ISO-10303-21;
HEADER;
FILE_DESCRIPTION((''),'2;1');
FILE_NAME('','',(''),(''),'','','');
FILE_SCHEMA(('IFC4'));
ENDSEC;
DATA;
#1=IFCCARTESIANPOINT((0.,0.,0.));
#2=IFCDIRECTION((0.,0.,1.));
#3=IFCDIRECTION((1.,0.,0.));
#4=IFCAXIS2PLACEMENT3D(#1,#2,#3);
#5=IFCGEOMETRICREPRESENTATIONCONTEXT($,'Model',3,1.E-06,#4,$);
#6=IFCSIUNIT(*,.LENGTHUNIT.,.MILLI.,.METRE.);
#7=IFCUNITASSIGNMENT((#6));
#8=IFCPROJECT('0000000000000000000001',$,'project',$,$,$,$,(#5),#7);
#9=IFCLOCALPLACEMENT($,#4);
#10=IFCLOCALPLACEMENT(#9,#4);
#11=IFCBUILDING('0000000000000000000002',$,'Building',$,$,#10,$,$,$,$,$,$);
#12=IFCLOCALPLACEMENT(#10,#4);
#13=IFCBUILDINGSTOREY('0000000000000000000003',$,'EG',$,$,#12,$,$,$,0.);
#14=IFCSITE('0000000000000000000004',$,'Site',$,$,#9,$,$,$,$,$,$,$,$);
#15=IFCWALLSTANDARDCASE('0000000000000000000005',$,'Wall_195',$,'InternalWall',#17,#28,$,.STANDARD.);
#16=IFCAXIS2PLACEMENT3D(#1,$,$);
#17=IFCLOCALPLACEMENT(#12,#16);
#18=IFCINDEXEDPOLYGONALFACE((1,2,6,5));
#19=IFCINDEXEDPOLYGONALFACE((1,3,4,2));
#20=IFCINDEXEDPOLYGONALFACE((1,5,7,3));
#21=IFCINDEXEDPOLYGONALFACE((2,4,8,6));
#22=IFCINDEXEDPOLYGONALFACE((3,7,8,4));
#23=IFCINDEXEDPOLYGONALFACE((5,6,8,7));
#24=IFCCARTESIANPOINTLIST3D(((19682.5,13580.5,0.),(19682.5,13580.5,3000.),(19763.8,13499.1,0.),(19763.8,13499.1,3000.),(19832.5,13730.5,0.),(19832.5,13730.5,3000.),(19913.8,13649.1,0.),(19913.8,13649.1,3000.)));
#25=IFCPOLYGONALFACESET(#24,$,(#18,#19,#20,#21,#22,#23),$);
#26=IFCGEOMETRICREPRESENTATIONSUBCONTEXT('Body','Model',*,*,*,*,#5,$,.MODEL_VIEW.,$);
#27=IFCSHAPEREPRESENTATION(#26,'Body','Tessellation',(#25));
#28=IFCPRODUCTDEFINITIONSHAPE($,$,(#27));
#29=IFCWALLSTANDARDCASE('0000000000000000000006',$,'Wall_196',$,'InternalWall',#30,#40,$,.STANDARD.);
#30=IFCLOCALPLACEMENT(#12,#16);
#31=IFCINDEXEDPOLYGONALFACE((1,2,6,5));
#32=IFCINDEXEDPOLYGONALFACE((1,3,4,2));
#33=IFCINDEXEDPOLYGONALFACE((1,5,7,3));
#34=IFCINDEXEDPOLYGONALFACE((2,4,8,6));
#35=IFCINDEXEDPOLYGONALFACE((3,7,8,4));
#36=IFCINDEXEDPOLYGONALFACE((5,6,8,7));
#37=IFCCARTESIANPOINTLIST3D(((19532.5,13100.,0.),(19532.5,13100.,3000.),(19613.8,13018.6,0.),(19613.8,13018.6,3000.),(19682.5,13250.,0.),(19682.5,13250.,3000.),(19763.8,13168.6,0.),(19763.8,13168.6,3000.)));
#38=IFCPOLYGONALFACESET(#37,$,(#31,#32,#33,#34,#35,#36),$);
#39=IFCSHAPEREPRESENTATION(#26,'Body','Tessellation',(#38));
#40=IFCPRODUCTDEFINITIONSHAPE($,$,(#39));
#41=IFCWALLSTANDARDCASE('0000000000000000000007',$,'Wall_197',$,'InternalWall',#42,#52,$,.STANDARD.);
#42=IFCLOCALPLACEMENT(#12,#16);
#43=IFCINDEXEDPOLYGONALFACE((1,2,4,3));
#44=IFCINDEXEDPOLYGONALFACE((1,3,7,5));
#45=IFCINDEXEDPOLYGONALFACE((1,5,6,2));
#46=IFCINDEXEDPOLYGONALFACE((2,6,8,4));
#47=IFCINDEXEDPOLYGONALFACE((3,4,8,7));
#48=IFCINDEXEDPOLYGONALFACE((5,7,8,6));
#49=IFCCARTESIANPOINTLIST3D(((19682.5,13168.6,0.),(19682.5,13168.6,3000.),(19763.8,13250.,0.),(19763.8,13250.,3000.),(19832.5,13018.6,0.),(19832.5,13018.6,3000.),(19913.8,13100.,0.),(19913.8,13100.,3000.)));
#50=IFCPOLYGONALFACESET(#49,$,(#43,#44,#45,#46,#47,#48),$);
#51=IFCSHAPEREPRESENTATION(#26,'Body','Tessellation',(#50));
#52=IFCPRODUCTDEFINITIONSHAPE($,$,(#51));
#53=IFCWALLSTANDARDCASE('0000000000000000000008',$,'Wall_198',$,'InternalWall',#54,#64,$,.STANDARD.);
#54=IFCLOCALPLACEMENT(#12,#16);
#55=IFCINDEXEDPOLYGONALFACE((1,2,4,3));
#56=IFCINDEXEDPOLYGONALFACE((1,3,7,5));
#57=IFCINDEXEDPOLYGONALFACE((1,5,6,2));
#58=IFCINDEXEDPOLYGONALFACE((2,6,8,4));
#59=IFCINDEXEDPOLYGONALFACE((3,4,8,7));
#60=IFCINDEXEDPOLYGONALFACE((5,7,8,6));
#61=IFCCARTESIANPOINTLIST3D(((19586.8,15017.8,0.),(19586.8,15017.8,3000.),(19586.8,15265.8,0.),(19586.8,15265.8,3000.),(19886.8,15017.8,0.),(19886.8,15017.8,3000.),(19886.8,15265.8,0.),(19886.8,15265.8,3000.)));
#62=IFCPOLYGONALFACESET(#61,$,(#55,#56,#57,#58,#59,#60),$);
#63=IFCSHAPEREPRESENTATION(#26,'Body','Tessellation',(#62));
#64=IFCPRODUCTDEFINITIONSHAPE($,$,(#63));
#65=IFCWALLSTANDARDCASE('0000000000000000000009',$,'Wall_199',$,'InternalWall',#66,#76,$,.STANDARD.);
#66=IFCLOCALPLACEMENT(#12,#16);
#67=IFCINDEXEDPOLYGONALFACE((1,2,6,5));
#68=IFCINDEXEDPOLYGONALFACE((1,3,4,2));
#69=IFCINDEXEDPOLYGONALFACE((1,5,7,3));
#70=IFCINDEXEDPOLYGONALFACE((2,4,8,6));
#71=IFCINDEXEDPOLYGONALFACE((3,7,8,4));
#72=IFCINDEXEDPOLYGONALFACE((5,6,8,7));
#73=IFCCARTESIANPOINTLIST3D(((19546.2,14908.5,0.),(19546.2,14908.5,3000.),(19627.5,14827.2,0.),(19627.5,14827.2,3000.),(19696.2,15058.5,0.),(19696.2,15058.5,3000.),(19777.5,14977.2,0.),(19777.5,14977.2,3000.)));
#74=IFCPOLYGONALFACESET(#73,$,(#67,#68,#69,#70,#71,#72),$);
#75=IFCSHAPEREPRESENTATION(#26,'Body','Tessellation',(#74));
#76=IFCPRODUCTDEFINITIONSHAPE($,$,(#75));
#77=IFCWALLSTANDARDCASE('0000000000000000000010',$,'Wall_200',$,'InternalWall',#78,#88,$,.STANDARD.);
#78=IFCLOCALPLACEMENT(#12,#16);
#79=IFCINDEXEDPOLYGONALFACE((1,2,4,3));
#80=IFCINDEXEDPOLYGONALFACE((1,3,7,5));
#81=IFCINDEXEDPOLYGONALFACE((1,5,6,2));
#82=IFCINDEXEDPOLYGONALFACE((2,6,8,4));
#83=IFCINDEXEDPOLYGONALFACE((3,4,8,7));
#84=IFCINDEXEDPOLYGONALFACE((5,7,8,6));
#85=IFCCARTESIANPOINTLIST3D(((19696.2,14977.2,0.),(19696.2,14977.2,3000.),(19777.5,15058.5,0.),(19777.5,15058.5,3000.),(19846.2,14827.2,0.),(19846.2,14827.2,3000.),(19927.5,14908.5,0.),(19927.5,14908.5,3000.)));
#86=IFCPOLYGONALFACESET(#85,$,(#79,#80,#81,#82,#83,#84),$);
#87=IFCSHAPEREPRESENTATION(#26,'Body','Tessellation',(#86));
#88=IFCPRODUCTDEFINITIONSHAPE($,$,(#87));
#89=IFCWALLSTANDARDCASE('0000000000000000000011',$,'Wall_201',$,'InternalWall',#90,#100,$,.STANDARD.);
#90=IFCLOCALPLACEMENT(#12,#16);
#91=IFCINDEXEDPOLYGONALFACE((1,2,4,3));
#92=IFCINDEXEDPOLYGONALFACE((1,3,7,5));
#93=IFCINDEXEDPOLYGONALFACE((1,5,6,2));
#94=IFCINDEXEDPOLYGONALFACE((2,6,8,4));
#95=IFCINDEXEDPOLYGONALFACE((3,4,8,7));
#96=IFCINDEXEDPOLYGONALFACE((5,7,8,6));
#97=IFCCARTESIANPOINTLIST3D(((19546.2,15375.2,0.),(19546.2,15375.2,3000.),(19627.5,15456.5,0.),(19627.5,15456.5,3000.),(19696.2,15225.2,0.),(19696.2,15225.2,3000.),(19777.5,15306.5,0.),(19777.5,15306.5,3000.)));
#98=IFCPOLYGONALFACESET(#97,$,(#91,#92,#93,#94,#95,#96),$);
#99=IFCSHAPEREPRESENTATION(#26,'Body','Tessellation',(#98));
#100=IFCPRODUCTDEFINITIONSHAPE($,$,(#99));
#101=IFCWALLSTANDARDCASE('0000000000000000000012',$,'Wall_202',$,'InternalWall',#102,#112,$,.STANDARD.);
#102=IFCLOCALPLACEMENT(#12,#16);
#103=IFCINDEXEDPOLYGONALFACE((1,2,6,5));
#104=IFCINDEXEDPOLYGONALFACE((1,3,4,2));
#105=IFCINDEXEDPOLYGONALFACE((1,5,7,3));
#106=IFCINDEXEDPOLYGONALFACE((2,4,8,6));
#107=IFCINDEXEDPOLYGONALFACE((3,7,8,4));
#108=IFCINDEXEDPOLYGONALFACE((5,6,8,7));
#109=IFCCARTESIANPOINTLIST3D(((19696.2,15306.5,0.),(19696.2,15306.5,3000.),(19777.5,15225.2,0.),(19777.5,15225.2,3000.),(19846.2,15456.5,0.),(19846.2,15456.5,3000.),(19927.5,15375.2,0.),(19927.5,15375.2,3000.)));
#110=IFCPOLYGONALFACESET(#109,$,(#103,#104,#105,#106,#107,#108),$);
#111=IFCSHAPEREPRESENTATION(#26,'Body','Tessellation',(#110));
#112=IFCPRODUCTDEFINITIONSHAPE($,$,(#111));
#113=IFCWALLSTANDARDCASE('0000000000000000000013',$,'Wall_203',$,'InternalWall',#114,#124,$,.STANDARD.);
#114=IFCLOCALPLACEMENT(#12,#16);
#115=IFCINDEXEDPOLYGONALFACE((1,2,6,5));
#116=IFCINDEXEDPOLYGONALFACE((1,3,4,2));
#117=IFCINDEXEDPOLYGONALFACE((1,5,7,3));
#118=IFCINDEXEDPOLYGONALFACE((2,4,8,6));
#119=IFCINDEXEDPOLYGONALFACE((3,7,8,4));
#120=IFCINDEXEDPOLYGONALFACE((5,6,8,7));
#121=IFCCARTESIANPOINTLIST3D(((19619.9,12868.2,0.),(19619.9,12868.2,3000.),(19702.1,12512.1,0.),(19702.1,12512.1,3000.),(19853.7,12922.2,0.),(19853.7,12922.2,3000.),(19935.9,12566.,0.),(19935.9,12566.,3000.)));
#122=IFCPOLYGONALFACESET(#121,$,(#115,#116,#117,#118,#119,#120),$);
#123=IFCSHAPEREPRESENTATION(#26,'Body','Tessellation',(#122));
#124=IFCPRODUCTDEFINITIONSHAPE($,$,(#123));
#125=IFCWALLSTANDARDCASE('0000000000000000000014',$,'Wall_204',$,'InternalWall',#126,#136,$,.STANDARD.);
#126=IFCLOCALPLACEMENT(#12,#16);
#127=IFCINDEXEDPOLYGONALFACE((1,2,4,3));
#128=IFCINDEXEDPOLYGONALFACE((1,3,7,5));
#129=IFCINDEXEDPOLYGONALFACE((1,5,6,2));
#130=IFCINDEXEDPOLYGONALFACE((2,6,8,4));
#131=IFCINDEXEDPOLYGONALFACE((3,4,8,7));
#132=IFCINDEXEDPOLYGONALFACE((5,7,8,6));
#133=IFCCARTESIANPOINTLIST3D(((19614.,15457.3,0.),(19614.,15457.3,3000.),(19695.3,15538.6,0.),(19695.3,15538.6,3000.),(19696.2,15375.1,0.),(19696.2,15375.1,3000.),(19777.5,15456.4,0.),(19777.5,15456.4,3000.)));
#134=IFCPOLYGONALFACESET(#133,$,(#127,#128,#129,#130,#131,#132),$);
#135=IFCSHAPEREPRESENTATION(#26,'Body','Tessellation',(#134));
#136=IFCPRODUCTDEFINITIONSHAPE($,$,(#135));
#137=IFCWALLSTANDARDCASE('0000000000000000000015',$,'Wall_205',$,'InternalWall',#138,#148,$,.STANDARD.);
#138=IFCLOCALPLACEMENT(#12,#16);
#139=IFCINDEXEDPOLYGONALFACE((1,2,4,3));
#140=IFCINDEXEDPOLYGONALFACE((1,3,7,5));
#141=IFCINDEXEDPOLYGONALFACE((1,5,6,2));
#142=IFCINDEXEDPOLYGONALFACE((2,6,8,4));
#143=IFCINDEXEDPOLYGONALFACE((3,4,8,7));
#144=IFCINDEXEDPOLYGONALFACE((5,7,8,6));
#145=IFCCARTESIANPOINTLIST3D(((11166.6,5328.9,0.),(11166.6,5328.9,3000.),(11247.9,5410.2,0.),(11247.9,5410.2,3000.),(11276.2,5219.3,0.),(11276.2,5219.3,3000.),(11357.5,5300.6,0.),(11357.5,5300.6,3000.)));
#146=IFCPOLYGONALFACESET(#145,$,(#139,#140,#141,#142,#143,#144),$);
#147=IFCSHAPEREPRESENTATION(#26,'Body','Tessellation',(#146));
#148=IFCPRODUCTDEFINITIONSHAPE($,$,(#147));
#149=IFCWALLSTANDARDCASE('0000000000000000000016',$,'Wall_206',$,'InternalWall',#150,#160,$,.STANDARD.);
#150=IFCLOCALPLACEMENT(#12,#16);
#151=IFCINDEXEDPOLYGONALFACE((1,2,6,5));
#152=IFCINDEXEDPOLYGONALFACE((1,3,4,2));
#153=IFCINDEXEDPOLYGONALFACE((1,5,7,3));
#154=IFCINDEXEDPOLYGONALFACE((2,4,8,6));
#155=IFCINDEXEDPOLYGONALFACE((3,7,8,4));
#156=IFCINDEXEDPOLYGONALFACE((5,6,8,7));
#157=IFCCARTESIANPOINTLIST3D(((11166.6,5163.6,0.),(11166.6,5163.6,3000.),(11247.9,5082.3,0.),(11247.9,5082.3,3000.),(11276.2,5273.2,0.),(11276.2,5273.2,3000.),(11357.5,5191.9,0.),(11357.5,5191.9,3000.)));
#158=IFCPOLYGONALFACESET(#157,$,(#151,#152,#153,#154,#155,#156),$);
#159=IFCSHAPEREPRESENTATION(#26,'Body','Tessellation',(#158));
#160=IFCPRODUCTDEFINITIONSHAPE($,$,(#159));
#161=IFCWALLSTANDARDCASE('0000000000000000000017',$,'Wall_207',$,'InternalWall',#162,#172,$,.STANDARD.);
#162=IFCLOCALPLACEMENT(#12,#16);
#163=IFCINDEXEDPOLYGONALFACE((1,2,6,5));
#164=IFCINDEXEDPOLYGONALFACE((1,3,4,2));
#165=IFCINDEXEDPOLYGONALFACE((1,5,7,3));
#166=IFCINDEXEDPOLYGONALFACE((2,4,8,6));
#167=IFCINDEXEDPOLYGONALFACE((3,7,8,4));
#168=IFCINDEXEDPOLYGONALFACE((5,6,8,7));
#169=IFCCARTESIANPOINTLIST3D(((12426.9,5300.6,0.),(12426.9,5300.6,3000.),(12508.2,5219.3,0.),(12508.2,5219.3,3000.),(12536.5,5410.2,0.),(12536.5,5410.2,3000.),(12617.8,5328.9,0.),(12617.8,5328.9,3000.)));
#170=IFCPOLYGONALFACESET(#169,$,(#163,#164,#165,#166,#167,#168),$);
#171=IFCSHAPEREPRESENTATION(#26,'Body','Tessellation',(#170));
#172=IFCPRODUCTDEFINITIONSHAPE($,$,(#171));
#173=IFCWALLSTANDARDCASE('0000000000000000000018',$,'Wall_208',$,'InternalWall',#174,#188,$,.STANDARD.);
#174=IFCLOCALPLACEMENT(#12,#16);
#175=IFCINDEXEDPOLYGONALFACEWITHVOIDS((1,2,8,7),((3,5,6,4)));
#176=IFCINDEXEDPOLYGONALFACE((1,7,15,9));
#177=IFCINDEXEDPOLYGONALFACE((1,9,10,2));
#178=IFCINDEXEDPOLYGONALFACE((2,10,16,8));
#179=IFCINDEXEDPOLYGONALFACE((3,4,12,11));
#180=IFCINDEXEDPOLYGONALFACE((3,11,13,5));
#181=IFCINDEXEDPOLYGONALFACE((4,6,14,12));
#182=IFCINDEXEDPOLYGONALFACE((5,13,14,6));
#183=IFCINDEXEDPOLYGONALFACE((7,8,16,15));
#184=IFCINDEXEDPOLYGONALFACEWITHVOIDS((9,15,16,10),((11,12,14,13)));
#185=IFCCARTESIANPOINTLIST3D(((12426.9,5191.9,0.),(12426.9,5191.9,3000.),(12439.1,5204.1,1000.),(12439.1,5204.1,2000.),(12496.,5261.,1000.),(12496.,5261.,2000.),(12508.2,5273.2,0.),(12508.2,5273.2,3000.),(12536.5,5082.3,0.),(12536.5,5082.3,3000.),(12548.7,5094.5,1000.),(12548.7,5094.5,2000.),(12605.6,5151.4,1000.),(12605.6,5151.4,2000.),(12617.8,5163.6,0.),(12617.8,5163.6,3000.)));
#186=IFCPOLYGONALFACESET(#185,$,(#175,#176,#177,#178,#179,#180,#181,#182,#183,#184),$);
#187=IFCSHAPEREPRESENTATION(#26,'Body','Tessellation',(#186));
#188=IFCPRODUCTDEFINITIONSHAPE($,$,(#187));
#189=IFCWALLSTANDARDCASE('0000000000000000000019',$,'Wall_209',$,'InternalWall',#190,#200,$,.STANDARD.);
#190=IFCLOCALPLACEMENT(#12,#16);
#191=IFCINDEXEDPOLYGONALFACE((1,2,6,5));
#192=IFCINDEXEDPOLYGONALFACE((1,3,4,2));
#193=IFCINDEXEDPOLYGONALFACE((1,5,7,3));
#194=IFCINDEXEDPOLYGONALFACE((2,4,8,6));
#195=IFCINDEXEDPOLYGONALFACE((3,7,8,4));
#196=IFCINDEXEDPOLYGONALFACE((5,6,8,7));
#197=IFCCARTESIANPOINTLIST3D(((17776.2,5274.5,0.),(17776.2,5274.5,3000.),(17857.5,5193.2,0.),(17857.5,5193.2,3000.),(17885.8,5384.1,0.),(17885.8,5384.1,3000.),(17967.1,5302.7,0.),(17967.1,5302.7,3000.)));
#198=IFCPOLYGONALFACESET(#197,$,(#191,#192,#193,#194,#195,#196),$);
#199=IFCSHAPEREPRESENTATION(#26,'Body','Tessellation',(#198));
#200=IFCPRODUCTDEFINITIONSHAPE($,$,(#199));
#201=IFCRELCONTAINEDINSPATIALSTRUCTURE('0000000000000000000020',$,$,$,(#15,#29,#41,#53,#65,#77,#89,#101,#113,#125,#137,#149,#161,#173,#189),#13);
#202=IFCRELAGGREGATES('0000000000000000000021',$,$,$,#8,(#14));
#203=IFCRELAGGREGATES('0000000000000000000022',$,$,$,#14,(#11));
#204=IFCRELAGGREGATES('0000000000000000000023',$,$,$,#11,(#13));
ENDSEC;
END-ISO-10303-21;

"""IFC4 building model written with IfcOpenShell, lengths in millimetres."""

from ifc_helpers import new_model, si_unit, frame, origin_with_axes, place, context, subcontext, project, spatial, rectangle, extrude, element, save


model = new_model("IFC4")

# Units and contexts
model_context = context("Model", 3, precision=1e-06, world=origin_with_axes())
body_context = subcontext(model_context, "Body", "Model", "MODEL_VIEW")
ifc_project = project(units=[si_unit("LENGTHUNIT", "METRE", prefix="MILLI")], contexts=[model_context])

# Site, building, storey
site_placement = place(None, origin_with_axes())
site = spatial("IfcSite", under=ifc_project, at=site_placement, Name="Site")
building_placement = place(site_placement, origin_with_axes())
building = spatial("IfcBuilding", under=site, at=building_placement, Name="Building")
storey_placement = place(building_placement, origin_with_axes())
storey = spatial("IfcBuildingStorey", under=building, at=storey_placement, Name="EG", Elevation=0.0)

# Walls
wall_1_placement = place(storey_placement, origin_with_axes())
element("IfcWallStandardCase", 1, at=wall_1_placement, inside=storey, Name="Wall_195", ObjectType="InternalWall", PredefinedType="STANDARD", context=body_context, shape_type="SweptSolid", body=[
    extrude(rectangle(XDim=212.1, YDim=115.0), frame((19798.1, 13614.8, 0.0), z_axis=(0.0, 0.0, 1.0), x_axis=(0.707107, 0.707107, 0.0)), (0.0, 0.0, 1.0), 3000.0),
])
wall_2_placement = place(storey_placement, origin_with_axes())
element("IfcWallStandardCase", 2, at=wall_2_placement, inside=storey, Name="Wall_196", ObjectType="InternalWall", PredefinedType="STANDARD", context=body_context, shape_type="SweptSolid", body=[
    extrude(rectangle(XDim=212.1, YDim=115.0), frame((19648.1, 13134.3, 0.0), z_axis=(0.0, 0.0, 1.0), x_axis=(-0.707107, -0.707107, 0.0)), (0.0, 0.0, 1.0), 3000.0),
])
wall_3_placement = place(storey_placement, origin_with_axes())
element("IfcWallStandardCase", 3, at=wall_3_placement, inside=storey, Name="Wall_197", ObjectType="InternalWall", PredefinedType="STANDARD", context=body_context, shape_type="SweptSolid", body=[
    extrude(rectangle(XDim=212.1, YDim=115.0), frame((19798.1, 13134.3, 0.0), z_axis=(0.0, 0.0, 1.0), x_axis=(0.707107, -0.707107, 0.0)), (0.0, 0.0, 1.0), 3000.0),
])
wall_4_placement = place(storey_placement, origin_with_axes())
element("IfcWallStandardCase", 4, at=wall_4_placement, inside=storey, Name="Wall_198", ObjectType="InternalWall", PredefinedType="STANDARD", context=body_context, shape_type="SweptSolid", body=[
    extrude(rectangle(XDim=248.0, YDim=300.0), frame((19736.8, 15141.8, 0.0), z_axis=(0.0, 0.0, 1.0), x_axis=(0.0, 1.0, 0.0)), (0.0, 0.0, 1.0), 3000.0),
])
wall_5_placement = place(storey_placement, origin_with_axes())
element("IfcWallStandardCase", 5, at=wall_5_placement, inside=storey, Name="Wall_199", ObjectType="InternalWall", PredefinedType="STANDARD", context=body_context, shape_type="SweptSolid", body=[
    extrude(rectangle(XDim=212.1, YDim=115.0), frame((19661.8, 14942.8, 0.0), z_axis=(0.0, 0.0, 1.0), x_axis=(-0.707107, -0.707107, 0.0)), (0.0, 0.0, 1.0), 3000.0),
])
wall_6_placement = place(storey_placement, origin_with_axes())
element("IfcWallStandardCase", 6, at=wall_6_placement, inside=storey, Name="Wall_200", ObjectType="InternalWall", PredefinedType="STANDARD", context=body_context, shape_type="SweptSolid", body=[
    extrude(rectangle(XDim=212.1, YDim=115.0), frame((19811.8, 14942.8, 0.0), z_axis=(0.0, 0.0, 1.0), x_axis=(0.707107, -0.707107, 0.0)), (0.0, 0.0, 1.0), 3000.0),
])
wall_7_placement = place(storey_placement, origin_with_axes())
element("IfcWallStandardCase", 7, at=wall_7_placement, inside=storey, Name="Wall_201", ObjectType="InternalWall", PredefinedType="STANDARD", context=body_context, shape_type="SweptSolid", body=[
    extrude(rectangle(XDim=212.1, YDim=115.0), frame((19661.8, 15340.8, 0.0), z_axis=(0.0, 0.0, 1.0), x_axis=(-0.707107, 0.707107, 0.0)), (0.0, 0.0, 1.0), 3000.0),
])
wall_8_placement = place(storey_placement, origin_with_axes())
element("IfcWallStandardCase", 8, at=wall_8_placement, inside=storey, Name="Wall_202", ObjectType="InternalWall", PredefinedType="STANDARD", context=body_context, shape_type="SweptSolid", body=[
    extrude(rectangle(XDim=212.1, YDim=115.0), frame((19811.8, 15340.8, 0.0), z_axis=(0.0, 0.0, 1.0), x_axis=(0.707107, 0.707107, 0.0)), (0.0, 0.0, 1.0), 3000.0),
])
wall_9_placement = place(storey_placement, origin_with_axes())
element("IfcWallStandardCase", 9, at=wall_9_placement, inside=storey, Name="Wall_203", ObjectType="InternalWall", PredefinedType="STANDARD", context=body_context, shape_type="SweptSolid", body=[
    extrude(rectangle(XDim=365.5, YDim=240.0), frame((19777.9, 12717.1, 0.0), z_axis=(0.0, 0.0, 1.0), x_axis=(-0.22486, 0.974391, 0.0)), (0.0, 0.0, 1.0), 3000.0),
])
wall_10_placement = place(storey_placement, origin_with_axes())
element("IfcWallStandardCase", 10, at=wall_10_placement, inside=storey, Name="Wall_204", ObjectType="InternalWall", PredefinedType="STANDARD", context=body_context, shape_type="SweptSolid", body=[
    extrude(rectangle(XDim=116.2, YDim=115.0), frame((19695.7, 15456.9, 0.0), z_axis=(0.0, 0.0, 1.0), x_axis=(-0.707107, 0.707107, 0.0)), (0.0, 0.0, 1.0), 3000.0),
])
wall_11_placement = place(storey_placement, origin_with_axes())
element("IfcWallStandardCase", 11, at=wall_11_placement, inside=storey, Name="Wall_205", ObjectType="InternalWall", PredefinedType="STANDARD", context=body_context, shape_type="SweptSolid", body=[
    extrude(rectangle(XDim=155.0, YDim=115.0), frame((11262.1, 5314.7, 0.0), z_axis=(0.0, 0.0, 1.0), x_axis=(-0.707107, 0.707107, 0.0)), (0.0, 0.0, 1.0), 3000.0),
])
wall_12_placement = place(storey_placement, origin_with_axes())
element("IfcWallStandardCase", 12, at=wall_12_placement, inside=storey, Name="Wall_206", ObjectType="InternalWall", PredefinedType="STANDARD", context=body_context, shape_type="SweptSolid", body=[
    extrude(rectangle(XDim=155.0, YDim=115.0), frame((11262.1, 5177.7, 0.0), z_axis=(0.0, 0.0, 1.0), x_axis=(-0.707107, -0.707107, 0.0)), (0.0, 0.0, 1.0), 3000.0),
])
wall_13_placement = place(storey_placement, origin_with_axes())
element("IfcWallStandardCase", 13, at=wall_13_placement, inside=storey, Name="Wall_207", ObjectType="InternalWall", PredefinedType="STANDARD", context=body_context, shape_type="SweptSolid", body=[
    extrude(rectangle(XDim=155.0, YDim=115.0), frame((12522.3, 5314.7, 0.0), z_axis=(0.0, 0.0, 1.0), x_axis=(0.707107, 0.707107, 0.0)), (0.0, 0.0, 1.0), 3000.0),
])

# Wall, opening
wall_14_placement = place(storey_placement, origin_with_axes())
wall_14 = element("IfcWallStandardCase", 14, at=wall_14_placement, inside=storey, Name="Wall_208", ObjectType="InternalWall", PredefinedType="STANDARD", context=body_context, shape_type="SweptSolid", body=[
    extrude(rectangle(XDim=155.0, YDim=115.0), frame((12522.3, 5177.7, 0.0), z_axis=(0.0, 0.0, 1.0), x_axis=(-0.707107, 0.707107, 0.0)), (0.0, 0.0, 1.0), 3000.0),
])
opening_1_placement = place(wall_14_placement, origin_with_axes())
element("IfcOpeningElement", 15, at=opening_1_placement, inside=storey, cuts=wall_14, context=body_context, shape_type="SweptSolid", body=[
    extrude(rectangle(XDim=1085.7, YDim=80.5), frame((12845.3, 4854.8, 1000.0), z_axis=(0.0, 0.0, 1.0), x_axis=(-0.707107, 0.707107, 0.0)), (0.0, 0.0, 1.0), 1000.0),
])

# Wall
wall_15_placement = place(storey_placement, origin_with_axes())
element("IfcWallStandardCase", 16, at=wall_15_placement, inside=storey, Name="Wall_209", ObjectType="InternalWall", PredefinedType="STANDARD", context=body_context, shape_type="SweptSolid", body=[
    extrude(rectangle(XDim=155.0, YDim=115.0), frame((17871.7, 5288.6, 0.0), z_axis=(0.0, 0.0, 1.0), x_axis=(0.707107, 0.707107, 0.0)), (0.0, 0.0, 1.0), 3000.0),
])

save(model, "model.ifc")
